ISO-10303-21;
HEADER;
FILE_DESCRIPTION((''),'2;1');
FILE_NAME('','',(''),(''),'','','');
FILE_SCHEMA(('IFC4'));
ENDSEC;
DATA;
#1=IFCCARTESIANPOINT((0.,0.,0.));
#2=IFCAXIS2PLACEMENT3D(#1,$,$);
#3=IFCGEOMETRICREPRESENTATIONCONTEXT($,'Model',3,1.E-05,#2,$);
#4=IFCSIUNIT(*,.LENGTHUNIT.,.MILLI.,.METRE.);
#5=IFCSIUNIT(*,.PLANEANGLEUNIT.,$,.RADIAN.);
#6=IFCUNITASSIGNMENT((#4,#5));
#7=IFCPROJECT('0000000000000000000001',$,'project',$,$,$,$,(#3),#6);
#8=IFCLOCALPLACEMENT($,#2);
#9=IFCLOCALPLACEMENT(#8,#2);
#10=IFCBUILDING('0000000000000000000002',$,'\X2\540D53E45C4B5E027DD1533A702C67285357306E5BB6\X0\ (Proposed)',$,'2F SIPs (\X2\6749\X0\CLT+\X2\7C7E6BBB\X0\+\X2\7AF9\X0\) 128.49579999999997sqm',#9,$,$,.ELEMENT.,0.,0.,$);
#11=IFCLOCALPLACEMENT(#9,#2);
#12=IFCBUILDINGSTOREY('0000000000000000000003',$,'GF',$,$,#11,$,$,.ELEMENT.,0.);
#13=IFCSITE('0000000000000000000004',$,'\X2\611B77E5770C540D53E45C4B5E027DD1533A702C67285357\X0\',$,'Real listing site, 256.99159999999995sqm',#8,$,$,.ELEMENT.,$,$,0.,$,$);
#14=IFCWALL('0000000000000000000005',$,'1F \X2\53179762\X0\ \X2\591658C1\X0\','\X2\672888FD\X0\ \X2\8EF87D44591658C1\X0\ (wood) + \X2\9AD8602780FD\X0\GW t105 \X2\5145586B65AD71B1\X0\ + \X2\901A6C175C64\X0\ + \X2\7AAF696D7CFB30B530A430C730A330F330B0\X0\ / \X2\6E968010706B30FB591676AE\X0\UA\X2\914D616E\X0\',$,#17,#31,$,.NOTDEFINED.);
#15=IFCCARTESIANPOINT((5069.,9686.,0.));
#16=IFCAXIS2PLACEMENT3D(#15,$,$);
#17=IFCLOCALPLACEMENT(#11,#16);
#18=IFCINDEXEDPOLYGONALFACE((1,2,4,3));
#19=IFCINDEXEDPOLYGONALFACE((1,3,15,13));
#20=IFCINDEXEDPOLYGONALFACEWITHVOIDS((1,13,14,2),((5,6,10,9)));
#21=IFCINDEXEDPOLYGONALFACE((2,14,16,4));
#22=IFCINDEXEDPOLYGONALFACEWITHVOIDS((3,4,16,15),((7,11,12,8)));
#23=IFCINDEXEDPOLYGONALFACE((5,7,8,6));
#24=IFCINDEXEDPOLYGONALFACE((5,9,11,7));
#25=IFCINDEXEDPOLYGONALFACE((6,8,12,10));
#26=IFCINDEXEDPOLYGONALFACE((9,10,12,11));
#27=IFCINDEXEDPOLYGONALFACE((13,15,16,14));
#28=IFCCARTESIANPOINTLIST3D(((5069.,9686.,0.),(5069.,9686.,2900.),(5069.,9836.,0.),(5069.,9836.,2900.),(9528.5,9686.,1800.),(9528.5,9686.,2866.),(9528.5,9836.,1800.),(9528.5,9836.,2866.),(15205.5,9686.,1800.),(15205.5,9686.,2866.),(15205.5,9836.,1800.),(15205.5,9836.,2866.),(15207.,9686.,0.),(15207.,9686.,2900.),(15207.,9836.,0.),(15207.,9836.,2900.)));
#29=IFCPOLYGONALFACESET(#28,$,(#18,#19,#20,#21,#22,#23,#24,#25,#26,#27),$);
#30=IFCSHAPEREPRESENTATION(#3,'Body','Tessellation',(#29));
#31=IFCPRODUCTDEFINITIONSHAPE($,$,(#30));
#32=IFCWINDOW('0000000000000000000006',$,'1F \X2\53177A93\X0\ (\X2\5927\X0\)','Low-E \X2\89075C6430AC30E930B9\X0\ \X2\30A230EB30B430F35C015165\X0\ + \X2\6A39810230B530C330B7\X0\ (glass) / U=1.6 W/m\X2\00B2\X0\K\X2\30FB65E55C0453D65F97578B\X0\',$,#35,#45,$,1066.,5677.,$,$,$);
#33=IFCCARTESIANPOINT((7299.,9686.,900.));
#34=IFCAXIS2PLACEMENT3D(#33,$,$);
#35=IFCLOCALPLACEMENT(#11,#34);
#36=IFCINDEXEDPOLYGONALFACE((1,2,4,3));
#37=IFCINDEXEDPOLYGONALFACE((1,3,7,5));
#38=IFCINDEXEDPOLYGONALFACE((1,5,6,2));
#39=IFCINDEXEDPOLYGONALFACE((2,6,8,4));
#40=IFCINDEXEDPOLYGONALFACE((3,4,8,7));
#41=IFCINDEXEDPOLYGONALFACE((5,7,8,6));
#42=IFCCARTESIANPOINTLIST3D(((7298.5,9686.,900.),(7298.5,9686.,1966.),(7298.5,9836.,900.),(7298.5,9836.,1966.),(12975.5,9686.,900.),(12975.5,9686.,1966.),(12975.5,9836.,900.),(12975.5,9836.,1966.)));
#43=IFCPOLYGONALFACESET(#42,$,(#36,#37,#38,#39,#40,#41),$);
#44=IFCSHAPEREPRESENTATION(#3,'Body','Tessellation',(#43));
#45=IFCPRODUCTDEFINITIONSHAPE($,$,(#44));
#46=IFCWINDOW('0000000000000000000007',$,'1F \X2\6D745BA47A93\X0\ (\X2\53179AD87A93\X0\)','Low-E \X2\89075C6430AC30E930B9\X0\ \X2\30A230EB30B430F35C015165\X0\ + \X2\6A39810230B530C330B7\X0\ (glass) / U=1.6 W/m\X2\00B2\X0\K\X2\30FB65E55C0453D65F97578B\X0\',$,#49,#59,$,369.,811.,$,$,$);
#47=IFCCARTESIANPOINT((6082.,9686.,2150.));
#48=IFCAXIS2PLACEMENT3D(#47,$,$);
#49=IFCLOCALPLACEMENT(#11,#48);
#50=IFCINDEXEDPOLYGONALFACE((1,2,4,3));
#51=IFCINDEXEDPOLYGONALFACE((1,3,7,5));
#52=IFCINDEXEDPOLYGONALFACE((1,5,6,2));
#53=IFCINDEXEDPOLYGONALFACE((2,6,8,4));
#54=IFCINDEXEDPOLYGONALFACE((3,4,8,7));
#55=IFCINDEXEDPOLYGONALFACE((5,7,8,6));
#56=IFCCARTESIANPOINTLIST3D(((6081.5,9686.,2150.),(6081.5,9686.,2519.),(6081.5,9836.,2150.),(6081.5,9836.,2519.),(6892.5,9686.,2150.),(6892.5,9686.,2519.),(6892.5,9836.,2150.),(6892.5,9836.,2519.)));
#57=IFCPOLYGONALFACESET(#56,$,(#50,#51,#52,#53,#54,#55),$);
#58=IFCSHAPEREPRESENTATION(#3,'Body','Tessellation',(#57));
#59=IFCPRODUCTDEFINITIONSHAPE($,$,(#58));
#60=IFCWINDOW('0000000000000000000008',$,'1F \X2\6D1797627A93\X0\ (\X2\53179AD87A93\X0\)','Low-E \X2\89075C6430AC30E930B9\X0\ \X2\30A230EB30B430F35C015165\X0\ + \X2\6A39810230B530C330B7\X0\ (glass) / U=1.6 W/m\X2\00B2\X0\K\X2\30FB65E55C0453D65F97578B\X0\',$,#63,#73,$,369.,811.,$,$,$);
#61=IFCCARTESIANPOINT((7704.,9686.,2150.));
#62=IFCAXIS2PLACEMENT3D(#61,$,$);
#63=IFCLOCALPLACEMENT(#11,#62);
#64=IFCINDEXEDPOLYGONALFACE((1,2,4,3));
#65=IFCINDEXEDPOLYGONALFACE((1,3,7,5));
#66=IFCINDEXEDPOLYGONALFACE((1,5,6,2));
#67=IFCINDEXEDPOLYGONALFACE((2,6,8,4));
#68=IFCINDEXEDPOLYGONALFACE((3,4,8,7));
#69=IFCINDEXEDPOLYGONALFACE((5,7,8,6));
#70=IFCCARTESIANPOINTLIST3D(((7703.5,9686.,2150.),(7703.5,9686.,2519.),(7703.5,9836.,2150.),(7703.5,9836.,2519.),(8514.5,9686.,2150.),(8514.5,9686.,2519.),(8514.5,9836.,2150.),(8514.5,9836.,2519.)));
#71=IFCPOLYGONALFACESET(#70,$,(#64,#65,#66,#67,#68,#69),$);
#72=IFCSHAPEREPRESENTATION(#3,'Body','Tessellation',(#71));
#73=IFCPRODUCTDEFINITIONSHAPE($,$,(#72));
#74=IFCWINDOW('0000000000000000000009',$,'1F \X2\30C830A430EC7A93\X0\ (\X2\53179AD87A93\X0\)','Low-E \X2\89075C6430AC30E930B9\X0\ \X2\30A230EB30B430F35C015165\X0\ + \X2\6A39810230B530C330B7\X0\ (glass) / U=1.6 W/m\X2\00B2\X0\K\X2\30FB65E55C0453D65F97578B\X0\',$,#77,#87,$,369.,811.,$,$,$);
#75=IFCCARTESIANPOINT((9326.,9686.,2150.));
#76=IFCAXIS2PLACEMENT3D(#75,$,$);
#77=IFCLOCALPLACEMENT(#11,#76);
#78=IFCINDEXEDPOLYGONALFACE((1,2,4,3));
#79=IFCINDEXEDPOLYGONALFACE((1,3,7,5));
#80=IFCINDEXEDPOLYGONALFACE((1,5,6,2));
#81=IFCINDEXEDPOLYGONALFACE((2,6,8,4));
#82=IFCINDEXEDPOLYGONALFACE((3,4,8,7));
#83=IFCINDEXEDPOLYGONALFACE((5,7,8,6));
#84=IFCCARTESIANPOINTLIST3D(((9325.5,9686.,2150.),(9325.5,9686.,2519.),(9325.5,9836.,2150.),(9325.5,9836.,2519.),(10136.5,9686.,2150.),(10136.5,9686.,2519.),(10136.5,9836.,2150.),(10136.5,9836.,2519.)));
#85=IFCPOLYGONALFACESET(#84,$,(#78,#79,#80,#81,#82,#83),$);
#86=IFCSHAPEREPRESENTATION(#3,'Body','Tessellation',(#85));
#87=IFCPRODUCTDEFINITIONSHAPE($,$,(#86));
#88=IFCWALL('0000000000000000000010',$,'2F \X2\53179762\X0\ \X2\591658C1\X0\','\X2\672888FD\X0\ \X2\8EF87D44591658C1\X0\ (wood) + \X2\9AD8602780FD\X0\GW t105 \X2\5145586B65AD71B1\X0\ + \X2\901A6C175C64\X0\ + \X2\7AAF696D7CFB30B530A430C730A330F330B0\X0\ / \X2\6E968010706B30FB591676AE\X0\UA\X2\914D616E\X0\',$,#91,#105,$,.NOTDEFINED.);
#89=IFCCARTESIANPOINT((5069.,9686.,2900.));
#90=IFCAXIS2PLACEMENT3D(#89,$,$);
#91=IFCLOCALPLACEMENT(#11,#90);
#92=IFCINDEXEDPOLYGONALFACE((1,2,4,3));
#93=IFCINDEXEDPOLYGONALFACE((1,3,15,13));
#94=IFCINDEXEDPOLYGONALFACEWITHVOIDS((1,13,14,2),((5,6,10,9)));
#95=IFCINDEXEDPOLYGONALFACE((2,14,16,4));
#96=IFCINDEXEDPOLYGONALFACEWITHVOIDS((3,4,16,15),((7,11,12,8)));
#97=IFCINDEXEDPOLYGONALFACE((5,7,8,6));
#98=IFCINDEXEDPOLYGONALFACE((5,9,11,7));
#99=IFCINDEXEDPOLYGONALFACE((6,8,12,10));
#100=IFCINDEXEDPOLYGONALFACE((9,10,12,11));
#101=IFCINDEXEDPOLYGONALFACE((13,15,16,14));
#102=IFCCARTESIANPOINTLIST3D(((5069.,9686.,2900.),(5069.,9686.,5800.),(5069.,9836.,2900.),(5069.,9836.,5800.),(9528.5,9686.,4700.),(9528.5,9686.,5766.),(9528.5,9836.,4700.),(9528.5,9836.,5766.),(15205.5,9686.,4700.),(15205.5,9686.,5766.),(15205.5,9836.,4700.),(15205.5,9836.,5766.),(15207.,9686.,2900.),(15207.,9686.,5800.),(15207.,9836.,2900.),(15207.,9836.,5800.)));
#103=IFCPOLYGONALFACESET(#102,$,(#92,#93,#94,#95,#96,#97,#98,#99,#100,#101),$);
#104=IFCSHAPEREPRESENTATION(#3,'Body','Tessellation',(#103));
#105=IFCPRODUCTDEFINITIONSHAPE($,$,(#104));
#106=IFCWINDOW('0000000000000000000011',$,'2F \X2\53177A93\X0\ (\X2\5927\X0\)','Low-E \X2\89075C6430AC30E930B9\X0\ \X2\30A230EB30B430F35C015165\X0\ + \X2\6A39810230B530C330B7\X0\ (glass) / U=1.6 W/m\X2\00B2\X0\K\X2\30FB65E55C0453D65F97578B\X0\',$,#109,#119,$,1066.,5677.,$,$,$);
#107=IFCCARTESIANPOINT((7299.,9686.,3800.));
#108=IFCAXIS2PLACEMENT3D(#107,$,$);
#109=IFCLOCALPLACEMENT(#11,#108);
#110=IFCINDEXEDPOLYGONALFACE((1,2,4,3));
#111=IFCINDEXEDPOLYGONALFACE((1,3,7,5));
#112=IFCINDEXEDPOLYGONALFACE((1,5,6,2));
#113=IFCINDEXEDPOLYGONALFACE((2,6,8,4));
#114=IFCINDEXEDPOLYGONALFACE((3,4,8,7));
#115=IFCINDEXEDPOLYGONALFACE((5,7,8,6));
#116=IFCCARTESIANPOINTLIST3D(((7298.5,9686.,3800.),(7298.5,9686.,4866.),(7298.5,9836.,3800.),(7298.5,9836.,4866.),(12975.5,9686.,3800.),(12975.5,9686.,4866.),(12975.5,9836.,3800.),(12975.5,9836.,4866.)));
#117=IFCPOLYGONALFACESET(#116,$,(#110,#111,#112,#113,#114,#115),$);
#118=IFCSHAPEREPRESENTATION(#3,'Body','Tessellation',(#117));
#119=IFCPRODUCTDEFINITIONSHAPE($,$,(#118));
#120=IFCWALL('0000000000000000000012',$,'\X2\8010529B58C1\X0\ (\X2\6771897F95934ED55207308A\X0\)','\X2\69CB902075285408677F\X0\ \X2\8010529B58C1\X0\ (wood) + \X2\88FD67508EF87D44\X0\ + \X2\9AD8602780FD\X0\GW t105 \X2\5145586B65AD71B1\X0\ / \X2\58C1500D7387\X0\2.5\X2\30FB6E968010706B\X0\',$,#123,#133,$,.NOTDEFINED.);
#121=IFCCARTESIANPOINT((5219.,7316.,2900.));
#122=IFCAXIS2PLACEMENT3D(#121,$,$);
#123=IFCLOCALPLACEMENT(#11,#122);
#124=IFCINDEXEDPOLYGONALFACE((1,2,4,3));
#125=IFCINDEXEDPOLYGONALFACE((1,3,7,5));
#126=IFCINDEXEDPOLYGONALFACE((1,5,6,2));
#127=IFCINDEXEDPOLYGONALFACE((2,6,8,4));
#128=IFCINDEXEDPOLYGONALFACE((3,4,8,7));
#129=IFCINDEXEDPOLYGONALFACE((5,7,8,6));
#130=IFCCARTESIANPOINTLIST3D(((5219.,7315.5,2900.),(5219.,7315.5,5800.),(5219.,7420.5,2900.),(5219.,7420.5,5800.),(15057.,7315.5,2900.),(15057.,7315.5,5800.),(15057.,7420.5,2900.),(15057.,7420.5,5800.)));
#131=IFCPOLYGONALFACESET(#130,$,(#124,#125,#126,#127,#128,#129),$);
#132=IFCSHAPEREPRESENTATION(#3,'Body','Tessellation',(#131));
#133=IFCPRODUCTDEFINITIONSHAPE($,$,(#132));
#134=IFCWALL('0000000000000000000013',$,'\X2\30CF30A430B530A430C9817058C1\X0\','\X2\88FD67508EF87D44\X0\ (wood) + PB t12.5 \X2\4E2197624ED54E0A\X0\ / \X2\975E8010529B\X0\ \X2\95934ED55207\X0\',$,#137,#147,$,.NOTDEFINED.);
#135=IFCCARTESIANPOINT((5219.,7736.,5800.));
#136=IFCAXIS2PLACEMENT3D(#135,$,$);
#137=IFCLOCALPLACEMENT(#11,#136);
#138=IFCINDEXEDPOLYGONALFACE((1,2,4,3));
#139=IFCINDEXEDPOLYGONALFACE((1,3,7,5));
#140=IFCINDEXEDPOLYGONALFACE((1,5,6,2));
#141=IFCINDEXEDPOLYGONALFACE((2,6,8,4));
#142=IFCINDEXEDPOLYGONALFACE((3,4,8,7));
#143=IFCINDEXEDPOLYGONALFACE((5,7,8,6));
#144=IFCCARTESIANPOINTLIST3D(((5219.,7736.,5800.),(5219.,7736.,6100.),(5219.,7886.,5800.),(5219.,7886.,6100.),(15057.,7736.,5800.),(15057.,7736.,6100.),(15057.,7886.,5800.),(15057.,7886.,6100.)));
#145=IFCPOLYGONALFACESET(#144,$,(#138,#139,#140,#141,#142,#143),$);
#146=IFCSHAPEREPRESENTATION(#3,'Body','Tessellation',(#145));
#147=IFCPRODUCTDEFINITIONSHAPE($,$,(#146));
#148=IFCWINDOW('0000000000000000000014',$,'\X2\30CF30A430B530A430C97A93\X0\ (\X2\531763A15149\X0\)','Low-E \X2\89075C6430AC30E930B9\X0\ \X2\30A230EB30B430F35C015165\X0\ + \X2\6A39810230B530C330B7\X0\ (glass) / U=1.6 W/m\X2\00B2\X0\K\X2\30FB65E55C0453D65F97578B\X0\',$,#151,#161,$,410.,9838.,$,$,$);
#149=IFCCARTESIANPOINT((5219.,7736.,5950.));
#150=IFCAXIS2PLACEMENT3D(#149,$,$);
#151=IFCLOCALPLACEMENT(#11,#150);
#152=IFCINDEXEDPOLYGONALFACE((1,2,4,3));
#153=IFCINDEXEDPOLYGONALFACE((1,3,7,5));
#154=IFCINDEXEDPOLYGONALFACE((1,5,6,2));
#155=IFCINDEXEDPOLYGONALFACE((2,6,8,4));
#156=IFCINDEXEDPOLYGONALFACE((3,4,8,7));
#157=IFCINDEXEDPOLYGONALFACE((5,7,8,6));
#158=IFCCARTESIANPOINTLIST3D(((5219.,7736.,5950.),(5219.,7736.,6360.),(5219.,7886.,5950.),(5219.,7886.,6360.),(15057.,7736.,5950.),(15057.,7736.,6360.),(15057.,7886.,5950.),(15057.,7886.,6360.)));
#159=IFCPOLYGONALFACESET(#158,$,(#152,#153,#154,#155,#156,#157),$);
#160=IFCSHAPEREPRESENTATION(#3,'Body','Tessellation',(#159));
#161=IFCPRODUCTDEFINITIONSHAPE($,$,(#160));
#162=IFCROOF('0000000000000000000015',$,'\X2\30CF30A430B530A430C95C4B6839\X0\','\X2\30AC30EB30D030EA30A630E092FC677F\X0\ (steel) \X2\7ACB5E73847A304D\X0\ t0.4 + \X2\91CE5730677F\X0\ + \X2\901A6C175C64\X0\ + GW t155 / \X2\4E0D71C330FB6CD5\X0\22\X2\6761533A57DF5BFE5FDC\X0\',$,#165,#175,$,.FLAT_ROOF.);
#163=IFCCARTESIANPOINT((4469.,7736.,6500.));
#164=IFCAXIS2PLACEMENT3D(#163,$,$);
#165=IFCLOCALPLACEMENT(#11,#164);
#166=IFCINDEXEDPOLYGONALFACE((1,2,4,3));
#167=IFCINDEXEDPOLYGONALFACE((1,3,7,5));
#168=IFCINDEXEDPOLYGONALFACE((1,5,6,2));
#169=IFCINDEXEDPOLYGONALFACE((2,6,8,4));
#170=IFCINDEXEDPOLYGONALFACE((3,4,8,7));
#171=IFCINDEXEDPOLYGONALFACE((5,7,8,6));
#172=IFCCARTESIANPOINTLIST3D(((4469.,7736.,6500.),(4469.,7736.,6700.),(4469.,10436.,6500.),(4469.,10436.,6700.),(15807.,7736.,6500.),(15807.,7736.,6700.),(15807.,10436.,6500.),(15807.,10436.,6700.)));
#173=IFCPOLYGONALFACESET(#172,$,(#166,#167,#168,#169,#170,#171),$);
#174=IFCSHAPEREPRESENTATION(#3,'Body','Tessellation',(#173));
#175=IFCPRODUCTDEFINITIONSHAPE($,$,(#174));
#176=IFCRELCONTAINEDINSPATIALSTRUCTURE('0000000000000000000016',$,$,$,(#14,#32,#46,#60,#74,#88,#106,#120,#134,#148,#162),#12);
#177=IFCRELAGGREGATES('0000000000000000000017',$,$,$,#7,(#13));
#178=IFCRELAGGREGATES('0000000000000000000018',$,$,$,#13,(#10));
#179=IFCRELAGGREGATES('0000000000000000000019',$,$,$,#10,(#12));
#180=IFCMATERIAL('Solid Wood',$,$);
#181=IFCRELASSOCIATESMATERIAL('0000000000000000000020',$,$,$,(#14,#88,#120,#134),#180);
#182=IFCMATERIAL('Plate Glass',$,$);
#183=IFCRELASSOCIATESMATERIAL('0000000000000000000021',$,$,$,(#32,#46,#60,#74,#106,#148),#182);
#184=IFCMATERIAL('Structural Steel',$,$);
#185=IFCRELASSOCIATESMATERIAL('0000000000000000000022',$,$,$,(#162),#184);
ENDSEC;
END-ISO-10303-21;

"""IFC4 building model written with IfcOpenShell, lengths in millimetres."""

from ifc_helpers import new_model, si_unit, frame, frame_2d, origin, place, context, project, spatial, rectangle, extrude, material, element, fill, save


model = new_model("IFC4")

# Units and contexts
model_context = context("Model", 3, precision=1e-05, world=origin())
ifc_project = project(units=[si_unit("LENGTHUNIT", "METRE", prefix="MILLI"), si_unit("PLANEANGLEUNIT", "RADIAN")], contexts=[model_context])

# Site, building, storey
site_placement = place(None, origin())
site = spatial("IfcSite", under=ifc_project, at=site_placement, Name="愛知県名古屋市緑区瀬木南", ObjectType="Real listing site, 256.99159999999995sqm", CompositionType="ELEMENT", RefElevation=0.0)
building_placement = place(site_placement, origin())
building = spatial("IfcBuilding", under=site, at=building_placement, Name="名古屋市緑区瀬木南の家 (Proposed)", ObjectType="2F SIPs (杉CLT+籾殻+竹) 128.49579999999997sqm", CompositionType="ELEMENT", ElevationOfRefHeight=0.0, ElevationOfTerrain=0.0)
storey_placement = place(building_placement, origin())
storey = spatial("IfcBuildingStorey", under=building, at=storey_placement, Name="GF", CompositionType="ELEMENT", Elevation=0.0)

# Wall, openings, windows
ifc_material_1 = material(Name="Solid Wood")
wall_1_placement = place(storey_placement, frame((5069.0, 9686.0, 0.0)))
wall_1 = element("IfcWall", 1, at=wall_1_placement, inside=storey, material=ifc_material_1, Name="1F 北面 外壁", Description="木製 軸組外壁 (wood) + 高性能GW t105 充填断熱 + 通気層 + 窯業系サイディング / 準耐火・外皮UA配慮", PredefinedType="NOTDEFINED", context=model_context, shape_type="SweptSolid", body=[
    extrude(rectangle(XDim=10138.0, YDim=150.0, at=frame_2d((5069.0, 75.0))), frame((5069.0, 9686.0, 0.0)), (0.0, 0.0, 1.0), 2900.0),
])
opening_1_placement = place(storey_placement, frame((7299.0, 9686.0, 900.0)))
opening_1 = element("IfcOpeningElement", 2, at=opening_1_placement, cuts=wall_1, PredefinedType="NOTDEFINED", context=model_context, shape_type="SweptSolid", body=[
    extrude(rectangle(XDim=5677.0, YDim=150.0, at=frame_2d((2838.0, 75.0))), frame((7299.0, 9686.0, 900.0)), (0.0, 0.0, 1.0), 1066.0),
])
opening_2_placement = place(storey_placement, frame((6082.0, 9686.0, 2150.0)))
opening_2 = element("IfcOpeningElement", 3, at=opening_2_placement, cuts=wall_1, PredefinedType="NOTDEFINED", context=model_context, shape_type="SweptSolid", body=[
    extrude(rectangle(XDim=811.0, YDim=150.0, at=frame_2d((405.0, 75.0))), frame((6082.0, 9686.0, 2150.0)), (0.0, 0.0, 1.0), 369.0),
])
opening_3_placement = place(storey_placement, frame((7704.0, 9686.0, 2150.0)))
opening_3 = element("IfcOpeningElement", 4, at=opening_3_placement, cuts=wall_1, PredefinedType="NOTDEFINED", context=model_context, shape_type="SweptSolid", body=[
    extrude(rectangle(XDim=811.0, YDim=150.0, at=frame_2d((405.0, 75.0))), frame((7704.0, 9686.0, 2150.0)), (0.0, 0.0, 1.0), 369.0),
])
opening_4_placement = place(storey_placement, frame((9326.0, 9686.0, 2150.0)))
opening_4 = element("IfcOpeningElement", 5, at=opening_4_placement, cuts=wall_1, PredefinedType="NOTDEFINED", context=model_context, shape_type="SweptSolid", body=[
    extrude(rectangle(XDim=811.0, YDim=150.0, at=frame_2d((405.0, 75.0))), frame((9326.0, 9686.0, 2150.0)), (0.0, 0.0, 1.0), 369.0),
])
ifc_material_2 = material(Name="Plate Glass")
window_1_placement = place(storey_placement, frame((7299.0, 9686.0, 900.0)))
window_1 = element("IfcWindow", 6, at=window_1_placement, inside=storey, material=ifc_material_2, Name="1F 北窓 (大)", Description="Low-E 複層ガラス アルゴン封入 + 樹脂サッシ (glass) / U=1.6 W/m²K・日射取得型", OverallHeight=1066.0, OverallWidth=5677.0, context=model_context, shape_type="SweptSolid", body=[
    extrude(rectangle(XDim=5677.0, YDim=150.0, at=frame_2d((2838.0, 75.0))), frame((7299.0, 9686.0, 900.0)), (0.0, 0.0, 1.0), 1066.0),
])
fill(opening_1, window_1)
window_2_placement = place(storey_placement, frame((6082.0, 9686.0, 2150.0)))
window_2 = element("IfcWindow", 7, at=window_2_placement, inside=storey, material=ifc_material_2, Name="1F 浴室窓 (北高窓)", Description="Low-E 複層ガラス アルゴン封入 + 樹脂サッシ (glass) / U=1.6 W/m²K・日射取得型", OverallHeight=369.0, OverallWidth=811.0, context=model_context, shape_type="SweptSolid", body=[
    extrude(rectangle(XDim=811.0, YDim=150.0, at=frame_2d((405.0, 75.0))), frame((6082.0, 9686.0, 2150.0)), (0.0, 0.0, 1.0), 369.0),
])
fill(opening_2, window_2)
window_3_placement = place(storey_placement, frame((7704.0, 9686.0, 2150.0)))
window_3 = element("IfcWindow", 8, at=window_3_placement, inside=storey, material=ifc_material_2, Name="1F 洗面窓 (北高窓)", Description="Low-E 複層ガラス アルゴン封入 + 樹脂サッシ (glass) / U=1.6 W/m²K・日射取得型", OverallHeight=369.0, OverallWidth=811.0, context=model_context, shape_type="SweptSolid", body=[
    extrude(rectangle(XDim=811.0, YDim=150.0, at=frame_2d((405.0, 75.0))), frame((7704.0, 9686.0, 2150.0)), (0.0, 0.0, 1.0), 369.0),
])
fill(opening_3, window_3)
window_4_placement = place(storey_placement, frame((9326.0, 9686.0, 2150.0)))
window_4 = element("IfcWindow", 9, at=window_4_placement, inside=storey, material=ifc_material_2, Name="1F トイレ窓 (北高窓)", Description="Low-E 複層ガラス アルゴン封入 + 樹脂サッシ (glass) / U=1.6 W/m²K・日射取得型", OverallHeight=369.0, OverallWidth=811.0, context=model_context, shape_type="SweptSolid", body=[
    extrude(rectangle(XDim=811.0, YDim=150.0, at=frame_2d((405.0, 75.0))), frame((9326.0, 9686.0, 2150.0)), (0.0, 0.0, 1.0), 369.0),
])
fill(opening_4, window_4)

# Wall, opening, window
wall_2_placement = place(storey_placement, frame((5069.0, 9686.0, 2900.0)))
wall_2 = element("IfcWall", 10, at=wall_2_placement, inside=storey, material=ifc_material_1, Name="2F 北面 外壁", Description="木製 軸組外壁 (wood) + 高性能GW t105 充填断熱 + 通気層 + 窯業系サイディング / 準耐火・外皮UA配慮", PredefinedType="NOTDEFINED", context=model_context, shape_type="SweptSolid", body=[
    extrude(rectangle(XDim=10138.0, YDim=150.0, at=frame_2d((5069.0, 75.0))), frame((5069.0, 9686.0, 2900.0)), (0.0, 0.0, 1.0), 2900.0),
])
opening_5_placement = place(storey_placement, frame((7299.0, 9686.0, 3800.0)))
opening_5 = element("IfcOpeningElement", 11, at=opening_5_placement, cuts=wall_2, PredefinedType="NOTDEFINED", context=model_context, shape_type="SweptSolid", body=[
    extrude(rectangle(XDim=5677.0, YDim=150.0, at=frame_2d((2838.0, 75.0))), frame((7299.0, 9686.0, 3800.0)), (0.0, 0.0, 1.0), 1066.0),
])
window_5_placement = place(storey_placement, frame((7299.0, 9686.0, 3800.0)))
window_5 = element("IfcWindow", 12, at=window_5_placement, inside=storey, material=ifc_material_2, Name="2F 北窓 (大)", Description="Low-E 複層ガラス アルゴン封入 + 樹脂サッシ (glass) / U=1.6 W/m²K・日射取得型", OverallHeight=1066.0, OverallWidth=5677.0, context=model_context, shape_type="SweptSolid", body=[
    extrude(rectangle(XDim=5677.0, YDim=150.0, at=frame_2d((2838.0, 75.0))), frame((7299.0, 9686.0, 3800.0)), (0.0, 0.0, 1.0), 1066.0),
])
fill(opening_5, window_5)

# Wall
wall_3_placement = place(storey_placement, frame((5219.0, 7316.0, 2900.0)))
element("IfcWall", 13, at=wall_3_placement, inside=storey, material=ifc_material_1, Name="耐力壁 (東西間仕切り)", Description="構造用合板 耐力壁 (wood) + 製材軸組 + 高性能GW t105 充填断熱 / 壁倍率2.5・準耐火", PredefinedType="NOTDEFINED", context=model_context, shape_type="SweptSolid", body=[
    extrude(rectangle(XDim=9838.0, YDim=105.0, at=frame_2d((4919.0, 52.0))), frame((5219.0, 7316.0, 2900.0)), (0.0, 0.0, 1.0), 2900.0),
])

# Wall, opening, window
wall_4_placement = place(storey_placement, frame((5219.0, 7736.0, 5800.0)))
wall_4 = element("IfcWall", 14, at=wall_4_placement, inside=storey, material=ifc_material_1, Name="ハイサイド腰壁", Description="製材軸組 (wood) + PB t12.5 両面仕上 / 非耐力 間仕切", PredefinedType="NOTDEFINED", context=model_context, shape_type="SweptSolid", body=[
    extrude(rectangle(XDim=9838.0, YDim=150.0, at=frame_2d((4919.0, 75.0))), frame((5219.0, 7736.0, 5800.0)), (0.0, 0.0, 1.0), 700.0),
])
opening_6_placement = place(storey_placement, frame((5219.0, 7736.0, 5950.0)))
opening_6 = element("IfcOpeningElement", 15, at=opening_6_placement, cuts=wall_4, PredefinedType="NOTDEFINED", context=model_context, shape_type="SweptSolid", body=[
    extrude(rectangle(XDim=9838.0, YDim=150.0, at=frame_2d((4919.0, 75.0))), frame((5219.0, 7736.0, 5950.0)), (0.0, 0.0, 1.0), 410.0),
])
window_6_placement = place(storey_placement, frame((5219.0, 7736.0, 5950.0)))
window_6 = element("IfcWindow", 16, at=window_6_placement, inside=storey, material=ifc_material_2, Name="ハイサイド窓 (北採光)", Description="Low-E 複層ガラス アルゴン封入 + 樹脂サッシ (glass) / U=1.6 W/m²K・日射取得型", OverallHeight=410.0, OverallWidth=9838.0, context=model_context, shape_type="SweptSolid", body=[
    extrude(rectangle(XDim=9838.0, YDim=150.0, at=frame_2d((4919.0, 75.0))), frame((5219.0, 7736.0, 5950.0)), (0.0, 0.0, 1.0), 410.0),
])
fill(opening_6, window_6)

# Roof
ifc_material_3 = material(Name="Structural Steel")
roof_placement = place(storey_placement, frame((4469.0, 7736.0, 6500.0)))
element("IfcRoof", 17, at=roof_placement, inside=storey, material=ifc_material_3, Name="ハイサイド屋根", Description="ガルバリウム鋼板 (steel) 立平葺き t0.4 + 野地板 + 通気層 + GW t155 / 不燃・法22条区域対応", PredefinedType="FLAT_ROOF", context=model_context, shape_type="SweptSolid", body=[
    extrude(rectangle(XDim=11338.0, YDim=2700.0, at=frame_2d((5669.0, 1350.0))), frame((4469.0, 7736.0, 6500.0)), (0.0, 0.0, 1.0), 200.0),
])

save(model, "model.ifc")
